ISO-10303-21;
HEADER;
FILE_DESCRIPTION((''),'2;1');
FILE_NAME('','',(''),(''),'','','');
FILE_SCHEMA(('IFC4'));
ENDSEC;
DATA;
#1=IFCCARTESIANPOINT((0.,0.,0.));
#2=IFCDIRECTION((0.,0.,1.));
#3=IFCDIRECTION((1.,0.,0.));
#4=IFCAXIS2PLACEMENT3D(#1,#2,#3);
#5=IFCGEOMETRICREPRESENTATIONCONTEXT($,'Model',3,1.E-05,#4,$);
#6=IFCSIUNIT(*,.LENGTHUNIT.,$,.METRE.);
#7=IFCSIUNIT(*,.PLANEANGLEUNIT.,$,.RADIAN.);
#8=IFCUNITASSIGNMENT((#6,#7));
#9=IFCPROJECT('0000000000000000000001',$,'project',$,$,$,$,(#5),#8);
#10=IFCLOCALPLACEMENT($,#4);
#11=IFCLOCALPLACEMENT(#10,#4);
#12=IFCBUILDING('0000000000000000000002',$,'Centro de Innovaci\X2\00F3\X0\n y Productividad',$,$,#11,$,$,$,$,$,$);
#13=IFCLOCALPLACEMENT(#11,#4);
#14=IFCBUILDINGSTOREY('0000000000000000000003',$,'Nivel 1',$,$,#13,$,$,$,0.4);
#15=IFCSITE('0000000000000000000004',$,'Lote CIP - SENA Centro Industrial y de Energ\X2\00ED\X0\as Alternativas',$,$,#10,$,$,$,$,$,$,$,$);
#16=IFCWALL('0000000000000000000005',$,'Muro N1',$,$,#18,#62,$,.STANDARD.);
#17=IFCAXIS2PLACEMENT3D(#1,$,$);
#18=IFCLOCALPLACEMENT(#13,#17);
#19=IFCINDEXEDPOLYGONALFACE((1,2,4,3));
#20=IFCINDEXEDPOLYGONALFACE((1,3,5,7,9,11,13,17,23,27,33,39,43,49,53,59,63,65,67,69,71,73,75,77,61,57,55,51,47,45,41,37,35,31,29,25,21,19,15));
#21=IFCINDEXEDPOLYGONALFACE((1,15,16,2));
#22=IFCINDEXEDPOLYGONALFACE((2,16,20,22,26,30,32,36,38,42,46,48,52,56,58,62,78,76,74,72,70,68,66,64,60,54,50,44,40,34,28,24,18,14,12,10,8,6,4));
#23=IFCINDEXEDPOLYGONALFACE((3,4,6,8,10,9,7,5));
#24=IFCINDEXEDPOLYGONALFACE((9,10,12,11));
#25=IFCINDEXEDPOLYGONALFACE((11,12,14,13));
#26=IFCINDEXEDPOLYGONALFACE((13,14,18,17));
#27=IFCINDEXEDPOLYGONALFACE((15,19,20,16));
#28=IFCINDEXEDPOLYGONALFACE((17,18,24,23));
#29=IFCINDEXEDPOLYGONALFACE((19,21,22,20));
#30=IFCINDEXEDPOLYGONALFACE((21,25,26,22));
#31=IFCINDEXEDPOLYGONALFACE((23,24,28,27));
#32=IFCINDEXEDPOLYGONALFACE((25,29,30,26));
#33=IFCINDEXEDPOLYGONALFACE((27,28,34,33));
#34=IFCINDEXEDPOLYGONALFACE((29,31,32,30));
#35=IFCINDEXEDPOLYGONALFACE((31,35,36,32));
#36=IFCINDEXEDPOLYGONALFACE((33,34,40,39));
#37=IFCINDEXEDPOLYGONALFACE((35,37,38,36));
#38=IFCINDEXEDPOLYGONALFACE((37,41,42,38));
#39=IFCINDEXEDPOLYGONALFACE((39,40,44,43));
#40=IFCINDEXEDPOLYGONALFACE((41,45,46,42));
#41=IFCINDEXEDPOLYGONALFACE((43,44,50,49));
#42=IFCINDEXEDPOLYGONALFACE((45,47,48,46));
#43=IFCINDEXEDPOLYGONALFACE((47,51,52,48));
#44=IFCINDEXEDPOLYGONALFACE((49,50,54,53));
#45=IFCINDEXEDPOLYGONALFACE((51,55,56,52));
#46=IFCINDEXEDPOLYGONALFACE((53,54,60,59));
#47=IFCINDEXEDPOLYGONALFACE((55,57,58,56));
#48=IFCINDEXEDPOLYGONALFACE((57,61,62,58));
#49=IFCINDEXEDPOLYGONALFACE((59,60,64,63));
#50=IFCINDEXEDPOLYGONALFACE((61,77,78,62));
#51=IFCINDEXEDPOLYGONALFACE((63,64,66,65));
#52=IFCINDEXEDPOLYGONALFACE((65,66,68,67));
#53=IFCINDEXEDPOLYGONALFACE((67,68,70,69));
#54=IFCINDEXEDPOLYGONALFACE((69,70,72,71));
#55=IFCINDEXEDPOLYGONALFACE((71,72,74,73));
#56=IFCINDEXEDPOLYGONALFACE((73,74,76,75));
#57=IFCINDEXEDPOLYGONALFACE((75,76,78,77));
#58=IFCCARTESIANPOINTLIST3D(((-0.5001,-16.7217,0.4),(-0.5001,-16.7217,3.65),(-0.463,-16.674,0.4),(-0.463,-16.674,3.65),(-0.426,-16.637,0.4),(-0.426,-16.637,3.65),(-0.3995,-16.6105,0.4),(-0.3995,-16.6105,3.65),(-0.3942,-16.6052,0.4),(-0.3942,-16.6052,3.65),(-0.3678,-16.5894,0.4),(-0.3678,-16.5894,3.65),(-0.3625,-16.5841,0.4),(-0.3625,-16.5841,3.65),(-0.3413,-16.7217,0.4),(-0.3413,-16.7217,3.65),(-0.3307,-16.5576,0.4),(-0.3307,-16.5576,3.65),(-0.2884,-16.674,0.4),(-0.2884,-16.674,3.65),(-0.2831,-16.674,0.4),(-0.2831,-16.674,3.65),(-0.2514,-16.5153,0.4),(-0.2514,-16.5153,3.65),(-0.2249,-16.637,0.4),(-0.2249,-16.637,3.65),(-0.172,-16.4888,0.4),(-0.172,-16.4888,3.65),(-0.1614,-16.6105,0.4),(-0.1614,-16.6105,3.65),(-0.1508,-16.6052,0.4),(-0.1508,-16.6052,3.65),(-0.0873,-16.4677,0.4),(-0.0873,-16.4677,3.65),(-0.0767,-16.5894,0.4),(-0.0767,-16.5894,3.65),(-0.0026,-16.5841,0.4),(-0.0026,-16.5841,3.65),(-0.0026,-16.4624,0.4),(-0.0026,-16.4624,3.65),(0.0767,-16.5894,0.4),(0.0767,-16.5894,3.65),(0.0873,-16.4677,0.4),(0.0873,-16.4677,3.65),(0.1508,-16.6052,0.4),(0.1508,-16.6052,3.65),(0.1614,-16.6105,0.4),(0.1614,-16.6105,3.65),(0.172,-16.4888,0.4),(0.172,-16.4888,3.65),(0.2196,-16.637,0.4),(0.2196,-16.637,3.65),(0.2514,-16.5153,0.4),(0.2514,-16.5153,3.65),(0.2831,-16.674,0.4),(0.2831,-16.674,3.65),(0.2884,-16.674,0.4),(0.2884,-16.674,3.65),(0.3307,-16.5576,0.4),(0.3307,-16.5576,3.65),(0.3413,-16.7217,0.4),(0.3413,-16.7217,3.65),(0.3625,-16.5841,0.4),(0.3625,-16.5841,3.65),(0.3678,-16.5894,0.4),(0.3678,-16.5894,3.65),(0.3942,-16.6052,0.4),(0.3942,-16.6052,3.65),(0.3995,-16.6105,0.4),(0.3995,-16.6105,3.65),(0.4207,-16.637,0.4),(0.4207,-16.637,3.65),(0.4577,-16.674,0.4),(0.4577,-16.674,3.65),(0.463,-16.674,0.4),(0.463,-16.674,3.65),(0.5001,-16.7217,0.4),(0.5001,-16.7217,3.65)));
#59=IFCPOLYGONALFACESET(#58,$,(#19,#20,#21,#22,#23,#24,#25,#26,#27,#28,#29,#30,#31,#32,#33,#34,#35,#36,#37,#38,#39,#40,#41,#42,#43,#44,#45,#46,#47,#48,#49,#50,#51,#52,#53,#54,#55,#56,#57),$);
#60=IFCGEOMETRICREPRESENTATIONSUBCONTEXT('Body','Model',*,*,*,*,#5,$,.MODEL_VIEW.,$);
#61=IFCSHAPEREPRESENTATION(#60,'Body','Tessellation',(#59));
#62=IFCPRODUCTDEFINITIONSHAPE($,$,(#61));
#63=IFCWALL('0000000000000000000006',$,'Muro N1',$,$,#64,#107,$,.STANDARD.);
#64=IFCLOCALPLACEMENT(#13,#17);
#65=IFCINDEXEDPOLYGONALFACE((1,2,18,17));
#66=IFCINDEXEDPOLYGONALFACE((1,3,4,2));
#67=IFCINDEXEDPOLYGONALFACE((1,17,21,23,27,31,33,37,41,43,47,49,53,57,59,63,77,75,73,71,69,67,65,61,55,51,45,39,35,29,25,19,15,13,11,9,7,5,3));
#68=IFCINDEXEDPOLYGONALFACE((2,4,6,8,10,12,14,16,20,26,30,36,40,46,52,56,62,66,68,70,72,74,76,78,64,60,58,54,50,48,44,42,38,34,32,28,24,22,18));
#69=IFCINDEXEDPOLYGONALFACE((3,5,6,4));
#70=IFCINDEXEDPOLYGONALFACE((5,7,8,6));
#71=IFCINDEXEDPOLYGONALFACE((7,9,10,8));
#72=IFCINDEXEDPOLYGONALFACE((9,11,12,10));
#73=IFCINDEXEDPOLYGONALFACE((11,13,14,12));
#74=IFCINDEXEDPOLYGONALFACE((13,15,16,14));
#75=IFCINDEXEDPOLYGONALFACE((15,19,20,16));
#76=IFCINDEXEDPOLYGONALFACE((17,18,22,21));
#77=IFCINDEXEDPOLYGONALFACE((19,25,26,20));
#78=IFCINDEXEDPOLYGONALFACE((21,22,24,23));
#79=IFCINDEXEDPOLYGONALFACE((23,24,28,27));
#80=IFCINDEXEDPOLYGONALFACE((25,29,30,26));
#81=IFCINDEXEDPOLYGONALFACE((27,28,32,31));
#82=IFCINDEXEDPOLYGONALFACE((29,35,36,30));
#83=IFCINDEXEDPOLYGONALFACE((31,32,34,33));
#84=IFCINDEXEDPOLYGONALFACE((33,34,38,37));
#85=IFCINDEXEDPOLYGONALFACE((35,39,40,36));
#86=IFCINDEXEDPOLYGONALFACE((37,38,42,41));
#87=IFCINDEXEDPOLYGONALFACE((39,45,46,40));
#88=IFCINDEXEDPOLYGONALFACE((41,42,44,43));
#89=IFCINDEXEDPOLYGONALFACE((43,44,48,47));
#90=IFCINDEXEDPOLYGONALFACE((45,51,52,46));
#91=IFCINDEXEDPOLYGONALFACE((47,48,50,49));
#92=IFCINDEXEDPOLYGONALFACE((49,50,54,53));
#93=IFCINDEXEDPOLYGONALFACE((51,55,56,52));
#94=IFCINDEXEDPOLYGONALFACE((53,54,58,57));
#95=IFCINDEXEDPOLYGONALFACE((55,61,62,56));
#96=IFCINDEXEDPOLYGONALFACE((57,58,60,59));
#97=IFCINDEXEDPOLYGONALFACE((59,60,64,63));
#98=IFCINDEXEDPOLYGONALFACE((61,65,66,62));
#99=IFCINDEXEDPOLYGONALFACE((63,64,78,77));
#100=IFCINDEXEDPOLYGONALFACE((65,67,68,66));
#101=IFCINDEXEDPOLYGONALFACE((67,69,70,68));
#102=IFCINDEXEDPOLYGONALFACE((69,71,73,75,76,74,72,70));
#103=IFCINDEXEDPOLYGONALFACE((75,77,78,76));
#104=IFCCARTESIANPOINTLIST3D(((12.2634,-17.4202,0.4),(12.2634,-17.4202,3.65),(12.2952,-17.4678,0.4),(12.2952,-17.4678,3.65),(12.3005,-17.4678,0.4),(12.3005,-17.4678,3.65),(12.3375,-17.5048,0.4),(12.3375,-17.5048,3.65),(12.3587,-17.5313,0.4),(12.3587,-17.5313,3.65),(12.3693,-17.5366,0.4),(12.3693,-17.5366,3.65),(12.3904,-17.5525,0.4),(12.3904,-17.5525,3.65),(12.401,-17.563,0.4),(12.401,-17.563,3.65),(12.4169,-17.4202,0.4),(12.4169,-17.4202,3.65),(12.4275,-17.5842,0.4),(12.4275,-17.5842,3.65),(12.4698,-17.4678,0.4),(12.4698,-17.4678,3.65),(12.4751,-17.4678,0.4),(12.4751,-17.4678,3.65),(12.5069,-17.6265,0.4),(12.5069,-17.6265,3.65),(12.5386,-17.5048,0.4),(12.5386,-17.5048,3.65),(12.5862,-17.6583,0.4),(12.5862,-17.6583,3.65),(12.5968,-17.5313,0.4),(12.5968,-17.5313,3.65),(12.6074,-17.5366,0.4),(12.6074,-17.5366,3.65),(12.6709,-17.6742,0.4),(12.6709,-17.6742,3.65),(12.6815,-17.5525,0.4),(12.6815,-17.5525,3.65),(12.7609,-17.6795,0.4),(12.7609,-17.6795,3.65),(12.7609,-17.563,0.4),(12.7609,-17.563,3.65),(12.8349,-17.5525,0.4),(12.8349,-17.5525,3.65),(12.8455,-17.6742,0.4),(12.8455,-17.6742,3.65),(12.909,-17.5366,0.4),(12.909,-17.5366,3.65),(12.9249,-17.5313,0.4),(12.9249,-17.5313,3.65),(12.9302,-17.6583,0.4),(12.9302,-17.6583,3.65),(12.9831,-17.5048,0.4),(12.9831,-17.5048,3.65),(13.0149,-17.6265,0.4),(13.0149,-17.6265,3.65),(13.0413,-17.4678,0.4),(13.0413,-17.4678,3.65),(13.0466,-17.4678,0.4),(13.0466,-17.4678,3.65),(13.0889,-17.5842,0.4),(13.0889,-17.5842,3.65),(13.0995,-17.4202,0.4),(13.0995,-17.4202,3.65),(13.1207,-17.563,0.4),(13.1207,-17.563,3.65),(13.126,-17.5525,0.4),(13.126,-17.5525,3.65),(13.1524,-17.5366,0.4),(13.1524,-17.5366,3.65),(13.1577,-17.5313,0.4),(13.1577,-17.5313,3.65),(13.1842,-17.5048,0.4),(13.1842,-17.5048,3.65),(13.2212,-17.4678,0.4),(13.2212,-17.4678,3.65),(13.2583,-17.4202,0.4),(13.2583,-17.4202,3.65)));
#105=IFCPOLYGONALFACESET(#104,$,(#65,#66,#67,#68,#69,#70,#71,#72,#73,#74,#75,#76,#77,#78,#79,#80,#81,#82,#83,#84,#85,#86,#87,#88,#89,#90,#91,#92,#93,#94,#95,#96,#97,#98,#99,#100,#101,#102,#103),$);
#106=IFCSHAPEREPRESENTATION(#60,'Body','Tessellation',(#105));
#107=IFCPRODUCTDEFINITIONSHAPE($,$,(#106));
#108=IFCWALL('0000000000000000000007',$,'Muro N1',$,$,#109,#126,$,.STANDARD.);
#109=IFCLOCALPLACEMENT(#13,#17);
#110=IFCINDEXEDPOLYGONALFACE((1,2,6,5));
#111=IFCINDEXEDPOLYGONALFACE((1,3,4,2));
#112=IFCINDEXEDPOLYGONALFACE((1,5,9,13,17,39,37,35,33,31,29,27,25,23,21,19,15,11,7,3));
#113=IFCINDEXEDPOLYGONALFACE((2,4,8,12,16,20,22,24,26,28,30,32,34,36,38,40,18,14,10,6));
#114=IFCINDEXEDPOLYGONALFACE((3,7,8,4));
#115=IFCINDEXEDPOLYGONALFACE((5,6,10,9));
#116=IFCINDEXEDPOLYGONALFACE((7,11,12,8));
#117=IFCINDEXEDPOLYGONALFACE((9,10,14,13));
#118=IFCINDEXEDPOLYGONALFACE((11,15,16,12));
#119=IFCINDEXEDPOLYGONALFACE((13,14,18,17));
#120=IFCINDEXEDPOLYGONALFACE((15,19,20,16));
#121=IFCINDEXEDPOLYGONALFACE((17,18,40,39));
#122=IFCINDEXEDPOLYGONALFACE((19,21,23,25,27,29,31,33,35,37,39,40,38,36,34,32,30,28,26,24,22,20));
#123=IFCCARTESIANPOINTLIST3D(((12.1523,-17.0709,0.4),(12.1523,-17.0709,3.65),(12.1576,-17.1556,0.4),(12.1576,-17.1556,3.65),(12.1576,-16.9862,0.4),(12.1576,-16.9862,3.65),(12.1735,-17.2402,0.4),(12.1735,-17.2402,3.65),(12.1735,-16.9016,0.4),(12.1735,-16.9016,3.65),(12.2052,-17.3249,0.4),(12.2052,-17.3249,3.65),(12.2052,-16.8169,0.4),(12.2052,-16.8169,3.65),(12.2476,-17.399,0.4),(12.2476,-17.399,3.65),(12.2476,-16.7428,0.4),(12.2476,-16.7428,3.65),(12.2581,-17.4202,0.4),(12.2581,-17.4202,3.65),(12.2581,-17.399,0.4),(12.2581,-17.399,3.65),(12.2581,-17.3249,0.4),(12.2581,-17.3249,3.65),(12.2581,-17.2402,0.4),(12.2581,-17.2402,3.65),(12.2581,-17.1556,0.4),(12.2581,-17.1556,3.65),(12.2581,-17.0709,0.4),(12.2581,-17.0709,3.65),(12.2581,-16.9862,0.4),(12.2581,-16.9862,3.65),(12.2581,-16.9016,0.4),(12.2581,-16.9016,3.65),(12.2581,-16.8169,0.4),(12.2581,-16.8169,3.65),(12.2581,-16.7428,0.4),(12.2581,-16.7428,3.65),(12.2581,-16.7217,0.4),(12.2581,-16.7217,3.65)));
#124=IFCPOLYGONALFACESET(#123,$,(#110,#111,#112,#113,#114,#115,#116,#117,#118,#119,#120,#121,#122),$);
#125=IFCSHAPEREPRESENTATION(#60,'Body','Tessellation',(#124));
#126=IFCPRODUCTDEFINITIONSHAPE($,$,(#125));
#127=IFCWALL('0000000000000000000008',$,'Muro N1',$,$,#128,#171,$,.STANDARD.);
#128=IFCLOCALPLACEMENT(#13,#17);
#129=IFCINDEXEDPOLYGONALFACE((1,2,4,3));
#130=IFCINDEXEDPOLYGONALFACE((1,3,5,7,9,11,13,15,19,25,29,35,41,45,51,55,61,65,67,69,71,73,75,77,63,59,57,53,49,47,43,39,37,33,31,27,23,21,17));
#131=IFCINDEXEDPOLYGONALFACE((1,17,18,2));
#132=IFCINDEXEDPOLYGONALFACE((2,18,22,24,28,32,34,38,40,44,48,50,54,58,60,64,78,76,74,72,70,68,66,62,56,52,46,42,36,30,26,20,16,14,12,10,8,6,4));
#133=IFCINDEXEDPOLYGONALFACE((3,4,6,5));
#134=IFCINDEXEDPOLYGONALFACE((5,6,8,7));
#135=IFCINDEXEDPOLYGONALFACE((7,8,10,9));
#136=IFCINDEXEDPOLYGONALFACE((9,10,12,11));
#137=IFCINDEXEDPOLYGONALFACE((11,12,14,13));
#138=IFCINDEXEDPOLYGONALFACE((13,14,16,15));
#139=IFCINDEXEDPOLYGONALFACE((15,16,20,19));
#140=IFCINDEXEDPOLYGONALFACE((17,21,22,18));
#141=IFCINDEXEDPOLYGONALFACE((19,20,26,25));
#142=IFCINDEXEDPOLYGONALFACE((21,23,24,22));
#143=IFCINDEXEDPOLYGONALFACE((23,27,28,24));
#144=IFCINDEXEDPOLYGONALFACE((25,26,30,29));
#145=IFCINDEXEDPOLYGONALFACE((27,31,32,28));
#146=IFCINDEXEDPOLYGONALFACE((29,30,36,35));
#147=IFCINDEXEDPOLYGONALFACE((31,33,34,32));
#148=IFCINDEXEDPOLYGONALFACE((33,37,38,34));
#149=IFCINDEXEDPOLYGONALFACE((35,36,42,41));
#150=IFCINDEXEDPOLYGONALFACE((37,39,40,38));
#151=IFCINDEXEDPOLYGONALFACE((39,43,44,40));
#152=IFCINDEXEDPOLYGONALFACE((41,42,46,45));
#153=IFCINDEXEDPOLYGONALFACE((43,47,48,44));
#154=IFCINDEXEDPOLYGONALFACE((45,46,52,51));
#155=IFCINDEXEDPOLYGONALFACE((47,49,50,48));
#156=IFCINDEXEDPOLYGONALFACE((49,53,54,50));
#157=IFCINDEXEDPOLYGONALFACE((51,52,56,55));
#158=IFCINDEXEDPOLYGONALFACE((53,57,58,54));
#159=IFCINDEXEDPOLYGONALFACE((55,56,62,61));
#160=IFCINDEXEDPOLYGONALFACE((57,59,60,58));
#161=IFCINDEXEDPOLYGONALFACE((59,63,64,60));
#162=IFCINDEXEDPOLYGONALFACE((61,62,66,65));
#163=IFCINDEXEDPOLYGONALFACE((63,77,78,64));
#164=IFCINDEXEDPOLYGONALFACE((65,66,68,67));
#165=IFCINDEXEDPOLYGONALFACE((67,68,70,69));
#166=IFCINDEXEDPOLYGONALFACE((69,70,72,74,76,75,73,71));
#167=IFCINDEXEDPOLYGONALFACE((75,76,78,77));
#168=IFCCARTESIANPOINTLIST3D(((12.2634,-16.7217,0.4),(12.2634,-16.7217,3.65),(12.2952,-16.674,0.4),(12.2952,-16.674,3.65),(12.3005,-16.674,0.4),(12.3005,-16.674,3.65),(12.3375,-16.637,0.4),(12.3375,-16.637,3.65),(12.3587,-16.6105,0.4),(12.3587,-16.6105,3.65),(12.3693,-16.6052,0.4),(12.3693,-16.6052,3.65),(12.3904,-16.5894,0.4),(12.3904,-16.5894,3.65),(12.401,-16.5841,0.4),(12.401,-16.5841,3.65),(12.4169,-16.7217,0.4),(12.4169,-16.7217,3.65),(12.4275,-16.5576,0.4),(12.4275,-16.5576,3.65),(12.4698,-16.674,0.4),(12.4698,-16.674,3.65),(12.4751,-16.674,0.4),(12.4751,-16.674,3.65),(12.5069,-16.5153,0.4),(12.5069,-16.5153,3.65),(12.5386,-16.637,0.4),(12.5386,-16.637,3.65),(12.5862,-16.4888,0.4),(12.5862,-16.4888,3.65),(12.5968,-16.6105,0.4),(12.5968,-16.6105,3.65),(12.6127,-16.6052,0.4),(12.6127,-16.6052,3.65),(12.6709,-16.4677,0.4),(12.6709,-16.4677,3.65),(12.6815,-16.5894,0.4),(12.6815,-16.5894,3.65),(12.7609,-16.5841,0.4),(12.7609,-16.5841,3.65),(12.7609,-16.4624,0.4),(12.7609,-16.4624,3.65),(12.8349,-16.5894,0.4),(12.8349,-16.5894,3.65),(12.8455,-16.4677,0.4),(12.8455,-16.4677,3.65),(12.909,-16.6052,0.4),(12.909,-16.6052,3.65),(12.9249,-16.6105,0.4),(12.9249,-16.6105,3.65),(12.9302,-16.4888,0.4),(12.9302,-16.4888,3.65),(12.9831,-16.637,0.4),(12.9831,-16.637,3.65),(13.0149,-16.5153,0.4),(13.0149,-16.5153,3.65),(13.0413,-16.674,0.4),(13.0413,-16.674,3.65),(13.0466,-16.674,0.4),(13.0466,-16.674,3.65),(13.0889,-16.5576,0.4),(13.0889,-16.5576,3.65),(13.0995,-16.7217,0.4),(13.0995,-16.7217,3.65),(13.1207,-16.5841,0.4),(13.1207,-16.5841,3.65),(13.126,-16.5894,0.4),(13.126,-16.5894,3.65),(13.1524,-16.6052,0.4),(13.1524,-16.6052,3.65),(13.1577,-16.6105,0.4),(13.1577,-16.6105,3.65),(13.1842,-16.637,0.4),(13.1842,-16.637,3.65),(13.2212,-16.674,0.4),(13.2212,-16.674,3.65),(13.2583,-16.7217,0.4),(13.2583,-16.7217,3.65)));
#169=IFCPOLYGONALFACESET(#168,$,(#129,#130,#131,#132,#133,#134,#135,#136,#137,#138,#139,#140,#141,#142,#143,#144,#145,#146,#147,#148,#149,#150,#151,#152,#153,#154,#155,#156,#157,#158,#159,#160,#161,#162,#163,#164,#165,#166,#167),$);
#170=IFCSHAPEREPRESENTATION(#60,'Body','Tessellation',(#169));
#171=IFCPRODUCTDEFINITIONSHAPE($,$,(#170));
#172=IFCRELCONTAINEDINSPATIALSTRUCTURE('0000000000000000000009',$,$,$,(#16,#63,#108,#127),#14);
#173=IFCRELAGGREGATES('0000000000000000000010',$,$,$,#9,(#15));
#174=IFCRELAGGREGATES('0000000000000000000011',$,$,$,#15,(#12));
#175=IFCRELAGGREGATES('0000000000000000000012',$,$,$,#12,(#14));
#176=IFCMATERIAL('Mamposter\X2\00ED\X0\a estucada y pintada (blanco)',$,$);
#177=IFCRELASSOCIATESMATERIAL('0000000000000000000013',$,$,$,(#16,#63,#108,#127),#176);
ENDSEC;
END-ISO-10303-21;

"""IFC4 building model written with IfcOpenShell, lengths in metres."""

from ifc_helpers import new_model, si_unit, frame, origin_with_axes, place, context, subcontext, project, spatial, polyline, outline, extrude, material, element, save


model = new_model("IFC4")

# Units and contexts
model_context = context("Model", 3, precision=1e-05, world=origin_with_axes())
body_context = subcontext(model_context, "Body", "Model", "MODEL_VIEW")
ifc_project = project(units=[si_unit("LENGTHUNIT", "METRE"), si_unit("PLANEANGLEUNIT", "RADIAN")], contexts=[model_context])

# Site, building, storey
site_placement = place(None, origin_with_axes())
site = spatial("IfcSite", under=ifc_project, at=site_placement, Name="Lote CIP - SENA Centro Industrial y de Energías Alternativas")
building_placement = place(site_placement, origin_with_axes())
building = spatial("IfcBuilding", under=site, at=building_placement, Name="Centro de Innovación y Productividad")
storey_placement = place(building_placement, origin_with_axes())
storey = spatial("IfcBuildingStorey", under=building, at=storey_placement, Name="Nivel 1", Elevation=0.4)

# Walls
ifc_material = material(Name="Mampostería estucada y pintada (blanco)")
wall_1_placement = place(storey_placement, origin_with_axes())
element("IfcWall", 1, at=wall_1_placement, inside=storey, material=ifc_material, Name="Muro N1", PredefinedType="STANDARD", context=body_context, shape_type="SweptSolid", body=[
    extrude(outline(polyline([(0.1508, -16.6052), (0.0767, -16.5894), (-0.0026, -16.5841), (-0.0767, -16.5894), (-0.1508, -16.6052), (-0.1614, -16.6105), (-0.2249, -16.637), (-0.2831, -16.674), (-0.2884, -16.674), (-0.3413, -16.7217), (-0.5001, -16.7217), (-0.463, -16.674), (-0.426, -16.637), (-0.3995, -16.6105), (-0.3942, -16.6052), (-0.3678, -16.5894), (-0.3625, -16.5841), (-0.3307, -16.5576), (-0.2514, -16.5153), (-0.172, -16.4888), (-0.0873, -16.4677), (-0.0026, -16.4624), (0.0873, -16.4677), (0.172, -16.4888), (0.2514, -16.5153), (0.3307, -16.5576), (0.3625, -16.5841), (0.3678, -16.5894), (0.3942, -16.6052), (0.3995, -16.6105), (0.4207, -16.637), (0.4577, -16.674), (0.463, -16.674), (0.5001, -16.7217), (0.3413, -16.7217), (0.2884, -16.674), (0.2831, -16.674), (0.2196, -16.637), (0.1614, -16.6105), (0.1508, -16.6052)])), frame((0.0, 0.0, 0.4)), (0.0, 0.0, 1.0), 3.25),
])
wall_2_placement = place(storey_placement, origin_with_axes())
element("IfcWall", 2, at=wall_2_placement, inside=storey, material=ifc_material, Name="Muro N1", PredefinedType="STANDARD", context=body_context, shape_type="SweptSolid", body=[
    extrude(outline(polyline([(12.5862, -17.6583), (12.5069, -17.6265), (12.4275, -17.5842), (12.401, -17.563), (12.3904, -17.5525), (12.3693, -17.5366), (12.3587, -17.5313), (12.3375, -17.5048), (12.3005, -17.4678), (12.2952, -17.4678), (12.2634, -17.4202), (12.4169, -17.4202), (12.4698, -17.4678), (12.4751, -17.4678), (12.5386, -17.5048), (12.5968, -17.5313), (12.6074, -17.5366), (12.6815, -17.5525), (12.7609, -17.563), (12.8349, -17.5525), (12.909, -17.5366), (12.9249, -17.5313), (12.9831, -17.5048), (13.0413, -17.4678), (13.0466, -17.4678), (13.0995, -17.4202), (13.2583, -17.4202), (13.2212, -17.4678), (13.1842, -17.5048), (13.1577, -17.5313), (13.1524, -17.5366), (13.126, -17.5525), (13.1207, -17.563), (13.0889, -17.5842), (13.0149, -17.6265), (12.9302, -17.6583), (12.8455, -17.6742), (12.7609, -17.6795), (12.6709, -17.6742), (12.5862, -17.6583)])), frame((0.0, 0.0, 0.4)), (0.0, 0.0, 1.0), 3.25),
])
wall_3_placement = place(storey_placement, origin_with_axes())
element("IfcWall", 3, at=wall_3_placement, inside=storey, material=ifc_material, Name="Muro N1", PredefinedType="STANDARD", context=body_context, shape_type="SweptSolid", body=[
    extrude(outline(polyline([(12.2052, -16.8169), (12.2476, -16.7428), (12.2581, -16.7217), (12.2581, -16.7428), (12.2581, -16.8169), (12.2581, -16.9016), (12.2581, -16.9862), (12.2581, -17.0709), (12.2581, -17.1556), (12.2581, -17.2402), (12.2581, -17.3249), (12.2581, -17.399), (12.2581, -17.4202), (12.2476, -17.399), (12.2052, -17.3249), (12.1735, -17.2402), (12.1576, -17.1556), (12.1523, -17.0709), (12.1576, -16.9862), (12.1735, -16.9016), (12.2052, -16.8169)])), frame((0.0, 0.0, 0.4)), (0.0, 0.0, 1.0), 3.25),
])
wall_4_placement = place(storey_placement, origin_with_axes())
element("IfcWall", 4, at=wall_4_placement, inside=storey, material=ifc_material, Name="Muro N1", PredefinedType="STANDARD", context=body_context, shape_type="SweptSolid", body=[
    extrude(outline(polyline([(12.4275, -16.5576), (12.5069, -16.5153), (12.5862, -16.4888), (12.6709, -16.4677), (12.7609, -16.4624), (12.8455, -16.4677), (12.9302, -16.4888), (13.0149, -16.5153), (13.0889, -16.5576), (13.1207, -16.5841), (13.126, -16.5894), (13.1524, -16.6052), (13.1577, -16.6105), (13.1842, -16.637), (13.2212, -16.674), (13.2583, -16.7217), (13.0995, -16.7217), (13.0466, -16.674), (13.0413, -16.674), (12.9831, -16.637), (12.9249, -16.6105), (12.909, -16.6052), (12.8349, -16.5894), (12.7609, -16.5841), (12.6815, -16.5894), (12.6127, -16.6052), (12.5968, -16.6105), (12.5386, -16.637), (12.4751, -16.674), (12.4698, -16.674), (12.4169, -16.7217), (12.2634, -16.7217), (12.2952, -16.674), (12.3005, -16.674), (12.3375, -16.637), (12.3587, -16.6105), (12.3693, -16.6052), (12.3904, -16.5894), (12.401, -16.5841), (12.4275, -16.5576)])), frame((0.0, 0.0, 0.4)), (0.0, 0.0, 1.0), 3.25),
])

save(model, "model.ifc")
